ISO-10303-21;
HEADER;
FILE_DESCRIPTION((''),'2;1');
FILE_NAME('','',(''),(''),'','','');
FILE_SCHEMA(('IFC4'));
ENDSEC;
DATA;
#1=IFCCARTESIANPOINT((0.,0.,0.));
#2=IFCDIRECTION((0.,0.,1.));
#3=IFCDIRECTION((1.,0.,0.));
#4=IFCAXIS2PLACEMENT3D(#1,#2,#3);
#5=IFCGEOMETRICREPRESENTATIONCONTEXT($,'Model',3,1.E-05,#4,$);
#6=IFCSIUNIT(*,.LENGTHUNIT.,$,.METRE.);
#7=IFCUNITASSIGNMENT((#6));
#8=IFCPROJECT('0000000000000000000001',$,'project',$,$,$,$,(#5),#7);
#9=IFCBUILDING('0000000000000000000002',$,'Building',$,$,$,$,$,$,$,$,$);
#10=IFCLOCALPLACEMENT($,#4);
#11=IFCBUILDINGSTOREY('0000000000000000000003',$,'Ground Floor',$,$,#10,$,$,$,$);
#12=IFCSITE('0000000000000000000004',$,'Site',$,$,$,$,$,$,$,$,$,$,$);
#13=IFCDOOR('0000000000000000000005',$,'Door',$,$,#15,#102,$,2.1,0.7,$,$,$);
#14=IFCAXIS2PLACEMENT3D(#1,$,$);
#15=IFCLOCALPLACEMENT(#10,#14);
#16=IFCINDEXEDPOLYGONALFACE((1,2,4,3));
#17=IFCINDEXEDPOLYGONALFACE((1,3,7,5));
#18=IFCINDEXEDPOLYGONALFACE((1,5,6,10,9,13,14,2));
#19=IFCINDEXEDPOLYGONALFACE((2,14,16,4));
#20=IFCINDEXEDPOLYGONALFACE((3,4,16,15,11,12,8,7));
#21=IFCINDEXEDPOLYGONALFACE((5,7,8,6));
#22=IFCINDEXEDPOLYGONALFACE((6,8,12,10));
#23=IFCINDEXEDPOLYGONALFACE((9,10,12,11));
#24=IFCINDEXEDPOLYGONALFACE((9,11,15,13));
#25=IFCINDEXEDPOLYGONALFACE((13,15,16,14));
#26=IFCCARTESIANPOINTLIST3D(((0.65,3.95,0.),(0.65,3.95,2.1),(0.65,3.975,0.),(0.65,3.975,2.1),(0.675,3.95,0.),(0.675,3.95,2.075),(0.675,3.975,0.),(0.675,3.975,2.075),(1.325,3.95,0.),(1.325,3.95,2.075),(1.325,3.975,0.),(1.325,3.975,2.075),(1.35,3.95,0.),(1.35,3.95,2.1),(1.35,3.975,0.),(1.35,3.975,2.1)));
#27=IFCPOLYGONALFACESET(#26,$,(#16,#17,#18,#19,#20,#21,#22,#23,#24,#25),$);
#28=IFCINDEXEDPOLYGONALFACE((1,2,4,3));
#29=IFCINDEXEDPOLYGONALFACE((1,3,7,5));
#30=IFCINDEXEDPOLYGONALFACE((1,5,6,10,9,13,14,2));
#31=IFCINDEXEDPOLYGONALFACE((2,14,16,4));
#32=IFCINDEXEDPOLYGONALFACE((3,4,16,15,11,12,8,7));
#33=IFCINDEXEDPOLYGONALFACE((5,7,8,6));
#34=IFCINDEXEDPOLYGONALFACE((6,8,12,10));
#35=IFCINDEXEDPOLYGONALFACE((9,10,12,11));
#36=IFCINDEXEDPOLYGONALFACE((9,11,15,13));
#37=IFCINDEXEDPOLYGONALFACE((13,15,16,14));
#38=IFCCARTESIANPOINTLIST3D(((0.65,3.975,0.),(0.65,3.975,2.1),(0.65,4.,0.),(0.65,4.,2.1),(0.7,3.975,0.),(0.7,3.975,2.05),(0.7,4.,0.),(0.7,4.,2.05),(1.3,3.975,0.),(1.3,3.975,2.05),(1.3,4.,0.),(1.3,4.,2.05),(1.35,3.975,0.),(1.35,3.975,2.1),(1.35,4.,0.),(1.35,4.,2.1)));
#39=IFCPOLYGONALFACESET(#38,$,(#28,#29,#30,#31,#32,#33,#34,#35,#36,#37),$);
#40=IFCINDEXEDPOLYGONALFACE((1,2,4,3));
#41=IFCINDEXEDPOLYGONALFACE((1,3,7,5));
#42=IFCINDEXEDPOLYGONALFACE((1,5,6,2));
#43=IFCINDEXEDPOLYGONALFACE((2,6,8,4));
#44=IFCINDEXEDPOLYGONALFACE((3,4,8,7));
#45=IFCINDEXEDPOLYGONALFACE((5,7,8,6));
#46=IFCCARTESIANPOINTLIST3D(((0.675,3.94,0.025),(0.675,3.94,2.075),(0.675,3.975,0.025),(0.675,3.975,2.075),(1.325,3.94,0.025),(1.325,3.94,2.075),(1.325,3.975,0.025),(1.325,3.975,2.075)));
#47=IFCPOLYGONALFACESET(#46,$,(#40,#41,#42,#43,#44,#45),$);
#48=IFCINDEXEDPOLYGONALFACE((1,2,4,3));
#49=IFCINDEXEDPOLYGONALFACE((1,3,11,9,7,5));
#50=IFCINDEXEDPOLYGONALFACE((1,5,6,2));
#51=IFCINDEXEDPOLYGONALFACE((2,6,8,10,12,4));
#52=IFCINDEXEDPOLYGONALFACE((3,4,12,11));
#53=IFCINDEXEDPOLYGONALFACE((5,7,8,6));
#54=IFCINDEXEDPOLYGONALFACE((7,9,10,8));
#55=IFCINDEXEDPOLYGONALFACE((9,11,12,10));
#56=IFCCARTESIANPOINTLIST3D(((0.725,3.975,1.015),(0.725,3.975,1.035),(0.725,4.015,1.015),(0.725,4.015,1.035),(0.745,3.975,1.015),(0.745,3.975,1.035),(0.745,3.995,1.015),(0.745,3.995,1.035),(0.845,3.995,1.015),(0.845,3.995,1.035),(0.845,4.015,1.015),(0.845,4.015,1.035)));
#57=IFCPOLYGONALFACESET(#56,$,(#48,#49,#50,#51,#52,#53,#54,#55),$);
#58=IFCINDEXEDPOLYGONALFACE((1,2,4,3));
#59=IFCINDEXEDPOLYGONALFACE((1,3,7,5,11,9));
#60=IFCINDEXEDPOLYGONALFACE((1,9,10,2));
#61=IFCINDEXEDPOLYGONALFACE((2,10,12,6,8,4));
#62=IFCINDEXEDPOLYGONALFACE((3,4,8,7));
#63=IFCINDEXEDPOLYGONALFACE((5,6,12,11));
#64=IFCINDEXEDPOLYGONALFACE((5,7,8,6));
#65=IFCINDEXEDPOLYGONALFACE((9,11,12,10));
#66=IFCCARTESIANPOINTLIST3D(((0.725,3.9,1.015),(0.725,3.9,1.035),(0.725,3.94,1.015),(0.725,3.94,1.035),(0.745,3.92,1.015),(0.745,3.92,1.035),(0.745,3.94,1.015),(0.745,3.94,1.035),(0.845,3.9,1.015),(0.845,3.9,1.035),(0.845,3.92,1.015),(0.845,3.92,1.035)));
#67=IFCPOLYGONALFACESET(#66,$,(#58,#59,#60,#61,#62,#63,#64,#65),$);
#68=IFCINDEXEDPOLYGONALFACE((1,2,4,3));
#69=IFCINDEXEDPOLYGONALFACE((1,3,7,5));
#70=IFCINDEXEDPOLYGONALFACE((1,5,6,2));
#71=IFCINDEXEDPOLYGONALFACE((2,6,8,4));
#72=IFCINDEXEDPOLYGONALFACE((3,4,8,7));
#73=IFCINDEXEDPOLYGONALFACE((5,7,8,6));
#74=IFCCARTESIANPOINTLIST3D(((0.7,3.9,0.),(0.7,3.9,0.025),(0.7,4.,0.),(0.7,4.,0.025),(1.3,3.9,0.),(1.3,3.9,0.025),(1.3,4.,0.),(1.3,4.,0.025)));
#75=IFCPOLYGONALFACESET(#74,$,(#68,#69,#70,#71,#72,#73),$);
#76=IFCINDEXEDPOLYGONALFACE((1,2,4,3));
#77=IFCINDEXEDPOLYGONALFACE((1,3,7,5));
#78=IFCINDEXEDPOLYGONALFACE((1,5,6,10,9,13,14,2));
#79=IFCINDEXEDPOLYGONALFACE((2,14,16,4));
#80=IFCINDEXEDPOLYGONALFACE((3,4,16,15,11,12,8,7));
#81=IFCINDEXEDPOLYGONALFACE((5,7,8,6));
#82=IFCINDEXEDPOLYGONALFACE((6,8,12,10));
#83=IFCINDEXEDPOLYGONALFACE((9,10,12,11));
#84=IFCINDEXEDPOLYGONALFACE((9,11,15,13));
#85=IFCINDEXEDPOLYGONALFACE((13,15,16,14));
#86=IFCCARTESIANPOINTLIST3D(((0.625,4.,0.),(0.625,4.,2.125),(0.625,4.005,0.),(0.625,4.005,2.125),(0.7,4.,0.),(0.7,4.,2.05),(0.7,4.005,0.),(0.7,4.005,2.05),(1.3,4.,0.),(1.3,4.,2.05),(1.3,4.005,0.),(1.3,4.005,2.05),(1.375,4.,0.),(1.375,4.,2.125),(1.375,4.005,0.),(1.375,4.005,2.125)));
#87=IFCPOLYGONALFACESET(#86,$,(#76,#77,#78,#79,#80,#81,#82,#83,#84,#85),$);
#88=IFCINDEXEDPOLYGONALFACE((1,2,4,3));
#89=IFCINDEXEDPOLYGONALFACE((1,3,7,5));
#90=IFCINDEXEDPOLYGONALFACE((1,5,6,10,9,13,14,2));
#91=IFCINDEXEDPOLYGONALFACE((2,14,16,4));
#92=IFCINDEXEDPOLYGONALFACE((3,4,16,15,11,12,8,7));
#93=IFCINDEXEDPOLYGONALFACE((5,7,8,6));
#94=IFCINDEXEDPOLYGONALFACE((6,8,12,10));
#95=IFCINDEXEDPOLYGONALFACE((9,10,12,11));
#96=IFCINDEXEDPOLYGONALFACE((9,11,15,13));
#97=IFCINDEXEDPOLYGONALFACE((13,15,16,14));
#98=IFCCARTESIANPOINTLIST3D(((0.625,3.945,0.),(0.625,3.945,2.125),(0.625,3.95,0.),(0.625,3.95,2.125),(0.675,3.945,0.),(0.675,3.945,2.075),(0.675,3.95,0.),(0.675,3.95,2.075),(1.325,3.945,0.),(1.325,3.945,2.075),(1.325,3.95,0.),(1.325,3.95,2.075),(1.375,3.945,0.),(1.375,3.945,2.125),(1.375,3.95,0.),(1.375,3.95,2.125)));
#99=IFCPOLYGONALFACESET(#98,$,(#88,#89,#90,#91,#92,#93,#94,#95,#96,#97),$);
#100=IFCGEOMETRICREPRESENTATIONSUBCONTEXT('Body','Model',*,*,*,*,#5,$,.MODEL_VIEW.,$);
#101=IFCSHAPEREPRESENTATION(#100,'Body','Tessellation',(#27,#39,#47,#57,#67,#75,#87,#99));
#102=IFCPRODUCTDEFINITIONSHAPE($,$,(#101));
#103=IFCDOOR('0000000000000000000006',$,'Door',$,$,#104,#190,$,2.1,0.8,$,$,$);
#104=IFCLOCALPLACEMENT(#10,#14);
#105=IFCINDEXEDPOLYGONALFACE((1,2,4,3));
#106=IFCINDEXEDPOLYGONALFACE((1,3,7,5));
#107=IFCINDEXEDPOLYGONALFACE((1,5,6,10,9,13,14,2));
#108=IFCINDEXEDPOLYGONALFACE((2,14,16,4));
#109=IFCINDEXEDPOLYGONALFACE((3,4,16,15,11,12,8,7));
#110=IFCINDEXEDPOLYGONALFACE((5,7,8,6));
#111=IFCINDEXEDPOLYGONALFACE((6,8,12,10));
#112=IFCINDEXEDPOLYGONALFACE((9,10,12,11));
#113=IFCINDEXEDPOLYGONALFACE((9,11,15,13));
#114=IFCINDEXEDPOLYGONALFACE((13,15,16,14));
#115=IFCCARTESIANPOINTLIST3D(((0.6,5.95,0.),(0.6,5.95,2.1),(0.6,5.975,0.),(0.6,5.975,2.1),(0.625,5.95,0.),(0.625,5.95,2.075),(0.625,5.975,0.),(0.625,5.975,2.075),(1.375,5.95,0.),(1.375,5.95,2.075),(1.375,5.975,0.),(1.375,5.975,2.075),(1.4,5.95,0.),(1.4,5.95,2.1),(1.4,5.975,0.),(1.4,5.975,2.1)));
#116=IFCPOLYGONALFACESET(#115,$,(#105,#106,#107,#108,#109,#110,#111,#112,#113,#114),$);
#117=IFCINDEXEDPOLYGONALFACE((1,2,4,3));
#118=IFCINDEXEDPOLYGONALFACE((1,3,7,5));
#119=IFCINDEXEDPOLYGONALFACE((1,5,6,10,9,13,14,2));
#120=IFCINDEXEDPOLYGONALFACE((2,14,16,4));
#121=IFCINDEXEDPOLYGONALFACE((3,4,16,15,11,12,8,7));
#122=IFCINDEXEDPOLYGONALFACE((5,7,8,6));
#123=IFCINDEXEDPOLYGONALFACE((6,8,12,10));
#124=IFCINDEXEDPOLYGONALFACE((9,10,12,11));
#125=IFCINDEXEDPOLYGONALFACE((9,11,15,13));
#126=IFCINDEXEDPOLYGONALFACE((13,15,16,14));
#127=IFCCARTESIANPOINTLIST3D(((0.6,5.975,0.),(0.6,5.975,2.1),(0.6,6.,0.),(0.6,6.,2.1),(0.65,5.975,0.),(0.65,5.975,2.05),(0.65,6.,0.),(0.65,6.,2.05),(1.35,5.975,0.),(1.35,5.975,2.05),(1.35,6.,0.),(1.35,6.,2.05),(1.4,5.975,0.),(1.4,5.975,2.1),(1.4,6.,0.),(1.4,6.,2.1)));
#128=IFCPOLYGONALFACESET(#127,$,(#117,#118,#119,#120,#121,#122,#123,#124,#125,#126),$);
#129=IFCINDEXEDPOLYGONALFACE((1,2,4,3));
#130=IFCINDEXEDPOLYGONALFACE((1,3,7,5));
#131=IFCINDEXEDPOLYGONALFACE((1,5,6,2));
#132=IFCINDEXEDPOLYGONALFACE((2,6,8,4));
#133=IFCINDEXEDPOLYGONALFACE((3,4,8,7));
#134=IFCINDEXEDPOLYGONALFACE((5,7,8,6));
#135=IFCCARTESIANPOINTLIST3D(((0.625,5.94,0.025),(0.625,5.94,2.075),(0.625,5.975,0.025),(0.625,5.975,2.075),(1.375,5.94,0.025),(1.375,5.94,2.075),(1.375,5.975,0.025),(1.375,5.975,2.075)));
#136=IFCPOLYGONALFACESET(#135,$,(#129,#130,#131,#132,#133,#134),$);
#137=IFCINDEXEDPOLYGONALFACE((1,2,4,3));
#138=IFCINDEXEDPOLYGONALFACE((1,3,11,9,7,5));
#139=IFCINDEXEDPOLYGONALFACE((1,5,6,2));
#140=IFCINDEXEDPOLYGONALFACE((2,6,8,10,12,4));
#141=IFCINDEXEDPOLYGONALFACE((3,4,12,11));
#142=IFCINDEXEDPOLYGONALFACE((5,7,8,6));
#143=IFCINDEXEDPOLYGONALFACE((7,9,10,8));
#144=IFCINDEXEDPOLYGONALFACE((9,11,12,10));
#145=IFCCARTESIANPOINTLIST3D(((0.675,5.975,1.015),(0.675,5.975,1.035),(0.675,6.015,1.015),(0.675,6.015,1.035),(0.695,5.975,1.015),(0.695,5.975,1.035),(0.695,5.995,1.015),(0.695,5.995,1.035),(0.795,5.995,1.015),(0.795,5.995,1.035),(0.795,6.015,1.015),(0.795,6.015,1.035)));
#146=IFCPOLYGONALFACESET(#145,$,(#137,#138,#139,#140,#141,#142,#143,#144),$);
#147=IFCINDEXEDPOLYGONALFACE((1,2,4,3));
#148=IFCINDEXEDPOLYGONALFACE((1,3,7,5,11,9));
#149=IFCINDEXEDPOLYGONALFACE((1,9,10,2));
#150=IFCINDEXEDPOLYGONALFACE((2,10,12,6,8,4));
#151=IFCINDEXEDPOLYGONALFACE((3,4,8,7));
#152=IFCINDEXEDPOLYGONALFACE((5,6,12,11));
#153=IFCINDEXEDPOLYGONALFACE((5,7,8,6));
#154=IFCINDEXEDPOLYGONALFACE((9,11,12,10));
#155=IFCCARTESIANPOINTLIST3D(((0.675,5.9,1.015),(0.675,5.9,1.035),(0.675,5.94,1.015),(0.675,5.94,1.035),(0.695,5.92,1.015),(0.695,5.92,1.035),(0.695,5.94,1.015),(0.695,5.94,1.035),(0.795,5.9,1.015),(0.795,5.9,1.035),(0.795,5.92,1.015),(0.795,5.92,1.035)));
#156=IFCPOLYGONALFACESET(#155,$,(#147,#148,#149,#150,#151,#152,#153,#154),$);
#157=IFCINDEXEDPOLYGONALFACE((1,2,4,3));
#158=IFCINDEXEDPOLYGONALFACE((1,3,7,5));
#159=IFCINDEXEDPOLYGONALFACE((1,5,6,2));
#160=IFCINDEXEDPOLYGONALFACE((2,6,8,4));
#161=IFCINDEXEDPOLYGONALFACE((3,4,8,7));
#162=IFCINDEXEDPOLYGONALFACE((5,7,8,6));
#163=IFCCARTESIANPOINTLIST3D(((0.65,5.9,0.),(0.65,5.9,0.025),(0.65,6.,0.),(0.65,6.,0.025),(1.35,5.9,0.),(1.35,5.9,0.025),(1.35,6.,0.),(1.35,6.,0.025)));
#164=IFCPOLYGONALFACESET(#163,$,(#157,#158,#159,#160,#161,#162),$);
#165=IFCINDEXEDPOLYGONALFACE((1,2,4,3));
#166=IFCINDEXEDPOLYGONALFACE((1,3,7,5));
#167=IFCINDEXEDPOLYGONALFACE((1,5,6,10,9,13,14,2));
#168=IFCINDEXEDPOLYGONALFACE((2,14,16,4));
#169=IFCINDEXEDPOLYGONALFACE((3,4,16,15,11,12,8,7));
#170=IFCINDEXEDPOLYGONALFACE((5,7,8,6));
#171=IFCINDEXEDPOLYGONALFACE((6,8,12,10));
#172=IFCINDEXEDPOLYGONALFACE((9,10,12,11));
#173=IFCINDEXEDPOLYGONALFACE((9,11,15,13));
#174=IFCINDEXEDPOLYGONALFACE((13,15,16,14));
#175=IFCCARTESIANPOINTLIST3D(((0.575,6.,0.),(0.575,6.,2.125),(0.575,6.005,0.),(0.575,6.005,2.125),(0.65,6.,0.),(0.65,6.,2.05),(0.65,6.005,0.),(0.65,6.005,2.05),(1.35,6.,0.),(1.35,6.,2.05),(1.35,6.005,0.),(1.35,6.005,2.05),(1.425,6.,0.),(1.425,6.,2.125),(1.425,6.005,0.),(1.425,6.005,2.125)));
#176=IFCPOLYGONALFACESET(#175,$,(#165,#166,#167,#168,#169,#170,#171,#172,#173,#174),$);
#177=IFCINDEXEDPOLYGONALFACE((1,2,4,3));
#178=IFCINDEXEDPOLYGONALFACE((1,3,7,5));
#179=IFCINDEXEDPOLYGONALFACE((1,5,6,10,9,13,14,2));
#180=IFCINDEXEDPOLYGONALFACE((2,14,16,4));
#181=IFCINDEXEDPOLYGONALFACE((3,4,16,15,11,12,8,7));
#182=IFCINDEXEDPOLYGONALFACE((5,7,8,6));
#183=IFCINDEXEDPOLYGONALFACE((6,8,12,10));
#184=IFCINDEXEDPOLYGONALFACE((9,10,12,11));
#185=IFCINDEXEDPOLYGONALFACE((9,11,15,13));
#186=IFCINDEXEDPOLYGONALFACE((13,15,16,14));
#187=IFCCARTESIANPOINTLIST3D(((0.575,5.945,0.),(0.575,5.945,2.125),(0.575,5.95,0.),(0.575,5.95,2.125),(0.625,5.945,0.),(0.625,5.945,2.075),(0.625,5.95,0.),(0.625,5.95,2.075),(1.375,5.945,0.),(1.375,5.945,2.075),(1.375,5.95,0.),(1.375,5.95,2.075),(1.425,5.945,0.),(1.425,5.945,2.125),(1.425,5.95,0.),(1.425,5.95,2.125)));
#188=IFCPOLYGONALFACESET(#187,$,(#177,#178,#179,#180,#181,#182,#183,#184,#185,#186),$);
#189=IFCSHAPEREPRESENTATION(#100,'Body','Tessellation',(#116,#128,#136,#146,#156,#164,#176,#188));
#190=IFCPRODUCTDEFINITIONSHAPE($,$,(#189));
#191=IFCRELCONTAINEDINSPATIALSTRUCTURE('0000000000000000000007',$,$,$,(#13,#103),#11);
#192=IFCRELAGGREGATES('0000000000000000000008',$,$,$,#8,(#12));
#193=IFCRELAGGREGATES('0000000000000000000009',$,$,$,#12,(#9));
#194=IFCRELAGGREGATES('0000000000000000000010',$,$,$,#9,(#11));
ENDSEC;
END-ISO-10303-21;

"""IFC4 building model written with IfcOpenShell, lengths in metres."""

from ifc_helpers import new_model, si_unit, frame, origin_with_axes, place, context, subcontext, project, spatial, line, indexed_curve, outline, extrude, element, save


model = new_model("IFC4")

# Units and contexts
model_context = context("Model", 3, precision=1e-05, world=origin_with_axes())
body_context = subcontext(model_context, "Body", "Model", "MODEL_VIEW")
ifc_project = project(units=[si_unit("LENGTHUNIT", "METRE")], contexts=[model_context])

# Site, building, storey
site = spatial("IfcSite", under=ifc_project, Name="Site")
building = spatial("IfcBuilding", under=site, Name="Building")
storey_placement = place(None, origin_with_axes())
storey = spatial("IfcBuildingStorey", under=building, at=storey_placement, Name="Ground Floor")

# Doors
door_1_placement = place(storey_placement, frame((1.35, 4.0, 0.0), z_axis=(0.0, 0.0, 1.0), x_axis=(-1.0, 0.0, 0.0)))
element("IfcDoor", 1, at=door_1_placement, inside=storey, Name="Door", OverallHeight=2.1, OverallWidth=0.7, context=body_context, shape_type="SweptSolid", body=[
    extrude(outline(indexed_curve([(0.0, 0.0), (0.0, 2.1), (0.7, 2.1), (0.7, 0.0), (0.675, 0.0), (0.675, 2.075), (0.025, 2.075), (0.025, 0.0)], segments=[line(1, 2, 3, 4, 5, 6, 7, 8, 1)])), frame((0.0, 0.025, 0.0), z_axis=(0.0, -1.0, 0.0), x_axis=(1.0, 0.0, 0.0)), (0.0, 0.0, -1.0), 0.025),
    extrude(outline(indexed_curve([(0.0, 0.0), (0.0, 2.1), (0.7, 2.1), (0.7, 0.0), (0.65, 0.0), (0.65, 2.05), (0.05, 2.05), (0.05, 0.0)], segments=[line(1, 2, 3, 4, 5, 6, 7, 8, 1)])), frame((0.0, 0.0, 0.0), z_axis=(0.0, -1.0, 0.0), x_axis=(1.0, 0.0, 0.0)), (0.0, 0.0, -1.0), 0.025),
    extrude(outline(indexed_curve([(0.0, 0.0), (0.65, 0.0), (0.65, 0.035), (0.0, 0.035)], segments=[line(1, 2, 3, 4, 1)])), frame((0.025, 0.025, 0.025), z_axis=(0.0, 0.0, 1.0), x_axis=(1.0, 0.0, 0.0)), (0.0, 0.0, 1.0), 2.05),
    extrude(outline(indexed_curve([(0.0, 0.0), (0.0, -0.04), (-0.12, -0.04), (-0.12, -0.02), (-0.02, -0.02), (-0.02, 0.0)], segments=[line(1, 2, 3, 4, 5, 6, 1)])), frame((0.625, 0.025, 1.015), z_axis=(0.0, 0.0, 1.0), x_axis=(1.0, 0.0, 0.0)), (0.0, 0.0, 1.0), 0.02),
    extrude(outline(indexed_curve([(0.0, 0.0), (0.0, 0.04), (-0.12, 0.04), (-0.12, 0.02), (-0.02, 0.02), (-0.02, 0.0)], segments=[line(1, 2, 3, 4, 5, 6, 1)])), frame((0.625, 0.06, 1.015), z_axis=(0.0, 0.0, 1.0), x_axis=(1.0, 0.0, 0.0)), (0.0, 0.0, 1.0), 0.02),
    extrude(outline(indexed_curve([(0.0, 0.0), (0.6, 0.0), (0.6, 0.1), (0.0, 0.1)], segments=[line(1, 2, 3, 4, 1)])), frame((0.05, 0.0, 0.0), z_axis=(0.0, 0.0, 1.0), x_axis=(1.0, 0.0, 0.0)), (0.0, 0.0, 1.0), 0.025),
    extrude(outline(indexed_curve([(0.0, 0.0), (0.0, 2.125), (0.75, 2.125), (0.75, 0.0), (0.675, 0.0), (0.675, 2.05), (0.075, 2.05), (0.075, 0.0)], segments=[line(1, 2, 3, 4, 5, 6, 7, 8, 1)])), frame((-0.025, -0.005, 0.0), z_axis=(0.0, -1.0, 0.0), x_axis=(1.0, 0.0, 0.0)), (0.0, 0.0, -1.0), 0.005),
    extrude(outline(indexed_curve([(0.0, 0.0), (0.0, 2.125), (0.75, 2.125), (0.75, 0.0), (0.7, 0.0), (0.7, 2.075), (0.05, 2.075), (0.05, 0.0)], segments=[line(1, 2, 3, 4, 5, 6, 7, 8, 1)])), frame((-0.025, 0.05, 0.0), z_axis=(0.0, -1.0, 0.0), x_axis=(1.0, 0.0, 0.0)), (0.0, 0.0, -1.0), 0.005),
])
door_2_placement = place(storey_placement, frame((1.4, 6.0, 0.0), z_axis=(0.0, 0.0, 1.0), x_axis=(-1.0, 0.0, 0.0)))
element("IfcDoor", 2, at=door_2_placement, inside=storey, Name="Door", OverallHeight=2.1, OverallWidth=0.8, context=body_context, shape_type="SweptSolid", body=[
    extrude(outline(indexed_curve([(0.0, 0.0), (0.0, 2.1), (0.8, 2.1), (0.8, 0.0), (0.775, 0.0), (0.775, 2.075), (0.025, 2.075), (0.025, 0.0)], segments=[line(1, 2, 3, 4, 5, 6, 7, 8, 1)])), frame((0.0, 0.025, 0.0), z_axis=(0.0, -1.0, 0.0), x_axis=(1.0, 0.0, 0.0)), (0.0, 0.0, -1.0), 0.025),
    extrude(outline(indexed_curve([(0.0, 0.0), (0.0, 2.1), (0.8, 2.1), (0.8, 0.0), (0.75, 0.0), (0.75, 2.05), (0.05, 2.05), (0.05, 0.0)], segments=[line(1, 2, 3, 4, 5, 6, 7, 8, 1)])), frame((0.0, 0.0, 0.0), z_axis=(0.0, -1.0, 0.0), x_axis=(1.0, 0.0, 0.0)), (0.0, 0.0, -1.0), 0.025),
    extrude(outline(indexed_curve([(0.0, 0.0), (0.75, 0.0), (0.75, 0.035), (0.0, 0.035)], segments=[line(1, 2, 3, 4, 1)])), frame((0.025, 0.025, 0.025), z_axis=(0.0, 0.0, 1.0), x_axis=(1.0, 0.0, 0.0)), (0.0, 0.0, 1.0), 2.05),
    extrude(outline(indexed_curve([(0.0, 0.0), (0.0, -0.04), (-0.12, -0.04), (-0.12, -0.02), (-0.02, -0.02), (-0.02, 0.0)], segments=[line(1, 2, 3, 4, 5, 6, 1)])), frame((0.725, 0.025, 1.015), z_axis=(0.0, 0.0, 1.0), x_axis=(1.0, 0.0, 0.0)), (0.0, 0.0, 1.0), 0.02),
    extrude(outline(indexed_curve([(0.0, 0.0), (0.0, 0.04), (-0.12, 0.04), (-0.12, 0.02), (-0.02, 0.02), (-0.02, 0.0)], segments=[line(1, 2, 3, 4, 5, 6, 1)])), frame((0.725, 0.06, 1.015), z_axis=(0.0, 0.0, 1.0), x_axis=(1.0, 0.0, 0.0)), (0.0, 0.0, 1.0), 0.02),
    extrude(outline(indexed_curve([(0.0, 0.0), (0.7, 0.0), (0.7, 0.1), (0.0, 0.1)], segments=[line(1, 2, 3, 4, 1)])), frame((0.05, 0.0, 0.0), z_axis=(0.0, 0.0, 1.0), x_axis=(1.0, 0.0, 0.0)), (0.0, 0.0, 1.0), 0.025),
    extrude(outline(indexed_curve([(0.0, 0.0), (0.0, 2.125), (0.85, 2.125), (0.85, 0.0), (0.775, 0.0), (0.775, 2.05), (0.075, 2.05), (0.075, 0.0)], segments=[line(1, 2, 3, 4, 5, 6, 7, 8, 1)])), frame((-0.025, -0.005, 0.0), z_axis=(0.0, -1.0, 0.0), x_axis=(1.0, 0.0, 0.0)), (0.0, 0.0, -1.0), 0.005),
    extrude(outline(indexed_curve([(0.0, 0.0), (0.0, 2.125), (0.85, 2.125), (0.85, 0.0), (0.8, 0.0), (0.8, 2.075), (0.05, 2.075), (0.05, 0.0)], segments=[line(1, 2, 3, 4, 5, 6, 7, 8, 1)])), frame((-0.025, 0.05, 0.0), z_axis=(0.0, -1.0, 0.0), x_axis=(1.0, 0.0, 0.0)), (0.0, 0.0, -1.0), 0.005),
])

save(model, "model.ifc")
